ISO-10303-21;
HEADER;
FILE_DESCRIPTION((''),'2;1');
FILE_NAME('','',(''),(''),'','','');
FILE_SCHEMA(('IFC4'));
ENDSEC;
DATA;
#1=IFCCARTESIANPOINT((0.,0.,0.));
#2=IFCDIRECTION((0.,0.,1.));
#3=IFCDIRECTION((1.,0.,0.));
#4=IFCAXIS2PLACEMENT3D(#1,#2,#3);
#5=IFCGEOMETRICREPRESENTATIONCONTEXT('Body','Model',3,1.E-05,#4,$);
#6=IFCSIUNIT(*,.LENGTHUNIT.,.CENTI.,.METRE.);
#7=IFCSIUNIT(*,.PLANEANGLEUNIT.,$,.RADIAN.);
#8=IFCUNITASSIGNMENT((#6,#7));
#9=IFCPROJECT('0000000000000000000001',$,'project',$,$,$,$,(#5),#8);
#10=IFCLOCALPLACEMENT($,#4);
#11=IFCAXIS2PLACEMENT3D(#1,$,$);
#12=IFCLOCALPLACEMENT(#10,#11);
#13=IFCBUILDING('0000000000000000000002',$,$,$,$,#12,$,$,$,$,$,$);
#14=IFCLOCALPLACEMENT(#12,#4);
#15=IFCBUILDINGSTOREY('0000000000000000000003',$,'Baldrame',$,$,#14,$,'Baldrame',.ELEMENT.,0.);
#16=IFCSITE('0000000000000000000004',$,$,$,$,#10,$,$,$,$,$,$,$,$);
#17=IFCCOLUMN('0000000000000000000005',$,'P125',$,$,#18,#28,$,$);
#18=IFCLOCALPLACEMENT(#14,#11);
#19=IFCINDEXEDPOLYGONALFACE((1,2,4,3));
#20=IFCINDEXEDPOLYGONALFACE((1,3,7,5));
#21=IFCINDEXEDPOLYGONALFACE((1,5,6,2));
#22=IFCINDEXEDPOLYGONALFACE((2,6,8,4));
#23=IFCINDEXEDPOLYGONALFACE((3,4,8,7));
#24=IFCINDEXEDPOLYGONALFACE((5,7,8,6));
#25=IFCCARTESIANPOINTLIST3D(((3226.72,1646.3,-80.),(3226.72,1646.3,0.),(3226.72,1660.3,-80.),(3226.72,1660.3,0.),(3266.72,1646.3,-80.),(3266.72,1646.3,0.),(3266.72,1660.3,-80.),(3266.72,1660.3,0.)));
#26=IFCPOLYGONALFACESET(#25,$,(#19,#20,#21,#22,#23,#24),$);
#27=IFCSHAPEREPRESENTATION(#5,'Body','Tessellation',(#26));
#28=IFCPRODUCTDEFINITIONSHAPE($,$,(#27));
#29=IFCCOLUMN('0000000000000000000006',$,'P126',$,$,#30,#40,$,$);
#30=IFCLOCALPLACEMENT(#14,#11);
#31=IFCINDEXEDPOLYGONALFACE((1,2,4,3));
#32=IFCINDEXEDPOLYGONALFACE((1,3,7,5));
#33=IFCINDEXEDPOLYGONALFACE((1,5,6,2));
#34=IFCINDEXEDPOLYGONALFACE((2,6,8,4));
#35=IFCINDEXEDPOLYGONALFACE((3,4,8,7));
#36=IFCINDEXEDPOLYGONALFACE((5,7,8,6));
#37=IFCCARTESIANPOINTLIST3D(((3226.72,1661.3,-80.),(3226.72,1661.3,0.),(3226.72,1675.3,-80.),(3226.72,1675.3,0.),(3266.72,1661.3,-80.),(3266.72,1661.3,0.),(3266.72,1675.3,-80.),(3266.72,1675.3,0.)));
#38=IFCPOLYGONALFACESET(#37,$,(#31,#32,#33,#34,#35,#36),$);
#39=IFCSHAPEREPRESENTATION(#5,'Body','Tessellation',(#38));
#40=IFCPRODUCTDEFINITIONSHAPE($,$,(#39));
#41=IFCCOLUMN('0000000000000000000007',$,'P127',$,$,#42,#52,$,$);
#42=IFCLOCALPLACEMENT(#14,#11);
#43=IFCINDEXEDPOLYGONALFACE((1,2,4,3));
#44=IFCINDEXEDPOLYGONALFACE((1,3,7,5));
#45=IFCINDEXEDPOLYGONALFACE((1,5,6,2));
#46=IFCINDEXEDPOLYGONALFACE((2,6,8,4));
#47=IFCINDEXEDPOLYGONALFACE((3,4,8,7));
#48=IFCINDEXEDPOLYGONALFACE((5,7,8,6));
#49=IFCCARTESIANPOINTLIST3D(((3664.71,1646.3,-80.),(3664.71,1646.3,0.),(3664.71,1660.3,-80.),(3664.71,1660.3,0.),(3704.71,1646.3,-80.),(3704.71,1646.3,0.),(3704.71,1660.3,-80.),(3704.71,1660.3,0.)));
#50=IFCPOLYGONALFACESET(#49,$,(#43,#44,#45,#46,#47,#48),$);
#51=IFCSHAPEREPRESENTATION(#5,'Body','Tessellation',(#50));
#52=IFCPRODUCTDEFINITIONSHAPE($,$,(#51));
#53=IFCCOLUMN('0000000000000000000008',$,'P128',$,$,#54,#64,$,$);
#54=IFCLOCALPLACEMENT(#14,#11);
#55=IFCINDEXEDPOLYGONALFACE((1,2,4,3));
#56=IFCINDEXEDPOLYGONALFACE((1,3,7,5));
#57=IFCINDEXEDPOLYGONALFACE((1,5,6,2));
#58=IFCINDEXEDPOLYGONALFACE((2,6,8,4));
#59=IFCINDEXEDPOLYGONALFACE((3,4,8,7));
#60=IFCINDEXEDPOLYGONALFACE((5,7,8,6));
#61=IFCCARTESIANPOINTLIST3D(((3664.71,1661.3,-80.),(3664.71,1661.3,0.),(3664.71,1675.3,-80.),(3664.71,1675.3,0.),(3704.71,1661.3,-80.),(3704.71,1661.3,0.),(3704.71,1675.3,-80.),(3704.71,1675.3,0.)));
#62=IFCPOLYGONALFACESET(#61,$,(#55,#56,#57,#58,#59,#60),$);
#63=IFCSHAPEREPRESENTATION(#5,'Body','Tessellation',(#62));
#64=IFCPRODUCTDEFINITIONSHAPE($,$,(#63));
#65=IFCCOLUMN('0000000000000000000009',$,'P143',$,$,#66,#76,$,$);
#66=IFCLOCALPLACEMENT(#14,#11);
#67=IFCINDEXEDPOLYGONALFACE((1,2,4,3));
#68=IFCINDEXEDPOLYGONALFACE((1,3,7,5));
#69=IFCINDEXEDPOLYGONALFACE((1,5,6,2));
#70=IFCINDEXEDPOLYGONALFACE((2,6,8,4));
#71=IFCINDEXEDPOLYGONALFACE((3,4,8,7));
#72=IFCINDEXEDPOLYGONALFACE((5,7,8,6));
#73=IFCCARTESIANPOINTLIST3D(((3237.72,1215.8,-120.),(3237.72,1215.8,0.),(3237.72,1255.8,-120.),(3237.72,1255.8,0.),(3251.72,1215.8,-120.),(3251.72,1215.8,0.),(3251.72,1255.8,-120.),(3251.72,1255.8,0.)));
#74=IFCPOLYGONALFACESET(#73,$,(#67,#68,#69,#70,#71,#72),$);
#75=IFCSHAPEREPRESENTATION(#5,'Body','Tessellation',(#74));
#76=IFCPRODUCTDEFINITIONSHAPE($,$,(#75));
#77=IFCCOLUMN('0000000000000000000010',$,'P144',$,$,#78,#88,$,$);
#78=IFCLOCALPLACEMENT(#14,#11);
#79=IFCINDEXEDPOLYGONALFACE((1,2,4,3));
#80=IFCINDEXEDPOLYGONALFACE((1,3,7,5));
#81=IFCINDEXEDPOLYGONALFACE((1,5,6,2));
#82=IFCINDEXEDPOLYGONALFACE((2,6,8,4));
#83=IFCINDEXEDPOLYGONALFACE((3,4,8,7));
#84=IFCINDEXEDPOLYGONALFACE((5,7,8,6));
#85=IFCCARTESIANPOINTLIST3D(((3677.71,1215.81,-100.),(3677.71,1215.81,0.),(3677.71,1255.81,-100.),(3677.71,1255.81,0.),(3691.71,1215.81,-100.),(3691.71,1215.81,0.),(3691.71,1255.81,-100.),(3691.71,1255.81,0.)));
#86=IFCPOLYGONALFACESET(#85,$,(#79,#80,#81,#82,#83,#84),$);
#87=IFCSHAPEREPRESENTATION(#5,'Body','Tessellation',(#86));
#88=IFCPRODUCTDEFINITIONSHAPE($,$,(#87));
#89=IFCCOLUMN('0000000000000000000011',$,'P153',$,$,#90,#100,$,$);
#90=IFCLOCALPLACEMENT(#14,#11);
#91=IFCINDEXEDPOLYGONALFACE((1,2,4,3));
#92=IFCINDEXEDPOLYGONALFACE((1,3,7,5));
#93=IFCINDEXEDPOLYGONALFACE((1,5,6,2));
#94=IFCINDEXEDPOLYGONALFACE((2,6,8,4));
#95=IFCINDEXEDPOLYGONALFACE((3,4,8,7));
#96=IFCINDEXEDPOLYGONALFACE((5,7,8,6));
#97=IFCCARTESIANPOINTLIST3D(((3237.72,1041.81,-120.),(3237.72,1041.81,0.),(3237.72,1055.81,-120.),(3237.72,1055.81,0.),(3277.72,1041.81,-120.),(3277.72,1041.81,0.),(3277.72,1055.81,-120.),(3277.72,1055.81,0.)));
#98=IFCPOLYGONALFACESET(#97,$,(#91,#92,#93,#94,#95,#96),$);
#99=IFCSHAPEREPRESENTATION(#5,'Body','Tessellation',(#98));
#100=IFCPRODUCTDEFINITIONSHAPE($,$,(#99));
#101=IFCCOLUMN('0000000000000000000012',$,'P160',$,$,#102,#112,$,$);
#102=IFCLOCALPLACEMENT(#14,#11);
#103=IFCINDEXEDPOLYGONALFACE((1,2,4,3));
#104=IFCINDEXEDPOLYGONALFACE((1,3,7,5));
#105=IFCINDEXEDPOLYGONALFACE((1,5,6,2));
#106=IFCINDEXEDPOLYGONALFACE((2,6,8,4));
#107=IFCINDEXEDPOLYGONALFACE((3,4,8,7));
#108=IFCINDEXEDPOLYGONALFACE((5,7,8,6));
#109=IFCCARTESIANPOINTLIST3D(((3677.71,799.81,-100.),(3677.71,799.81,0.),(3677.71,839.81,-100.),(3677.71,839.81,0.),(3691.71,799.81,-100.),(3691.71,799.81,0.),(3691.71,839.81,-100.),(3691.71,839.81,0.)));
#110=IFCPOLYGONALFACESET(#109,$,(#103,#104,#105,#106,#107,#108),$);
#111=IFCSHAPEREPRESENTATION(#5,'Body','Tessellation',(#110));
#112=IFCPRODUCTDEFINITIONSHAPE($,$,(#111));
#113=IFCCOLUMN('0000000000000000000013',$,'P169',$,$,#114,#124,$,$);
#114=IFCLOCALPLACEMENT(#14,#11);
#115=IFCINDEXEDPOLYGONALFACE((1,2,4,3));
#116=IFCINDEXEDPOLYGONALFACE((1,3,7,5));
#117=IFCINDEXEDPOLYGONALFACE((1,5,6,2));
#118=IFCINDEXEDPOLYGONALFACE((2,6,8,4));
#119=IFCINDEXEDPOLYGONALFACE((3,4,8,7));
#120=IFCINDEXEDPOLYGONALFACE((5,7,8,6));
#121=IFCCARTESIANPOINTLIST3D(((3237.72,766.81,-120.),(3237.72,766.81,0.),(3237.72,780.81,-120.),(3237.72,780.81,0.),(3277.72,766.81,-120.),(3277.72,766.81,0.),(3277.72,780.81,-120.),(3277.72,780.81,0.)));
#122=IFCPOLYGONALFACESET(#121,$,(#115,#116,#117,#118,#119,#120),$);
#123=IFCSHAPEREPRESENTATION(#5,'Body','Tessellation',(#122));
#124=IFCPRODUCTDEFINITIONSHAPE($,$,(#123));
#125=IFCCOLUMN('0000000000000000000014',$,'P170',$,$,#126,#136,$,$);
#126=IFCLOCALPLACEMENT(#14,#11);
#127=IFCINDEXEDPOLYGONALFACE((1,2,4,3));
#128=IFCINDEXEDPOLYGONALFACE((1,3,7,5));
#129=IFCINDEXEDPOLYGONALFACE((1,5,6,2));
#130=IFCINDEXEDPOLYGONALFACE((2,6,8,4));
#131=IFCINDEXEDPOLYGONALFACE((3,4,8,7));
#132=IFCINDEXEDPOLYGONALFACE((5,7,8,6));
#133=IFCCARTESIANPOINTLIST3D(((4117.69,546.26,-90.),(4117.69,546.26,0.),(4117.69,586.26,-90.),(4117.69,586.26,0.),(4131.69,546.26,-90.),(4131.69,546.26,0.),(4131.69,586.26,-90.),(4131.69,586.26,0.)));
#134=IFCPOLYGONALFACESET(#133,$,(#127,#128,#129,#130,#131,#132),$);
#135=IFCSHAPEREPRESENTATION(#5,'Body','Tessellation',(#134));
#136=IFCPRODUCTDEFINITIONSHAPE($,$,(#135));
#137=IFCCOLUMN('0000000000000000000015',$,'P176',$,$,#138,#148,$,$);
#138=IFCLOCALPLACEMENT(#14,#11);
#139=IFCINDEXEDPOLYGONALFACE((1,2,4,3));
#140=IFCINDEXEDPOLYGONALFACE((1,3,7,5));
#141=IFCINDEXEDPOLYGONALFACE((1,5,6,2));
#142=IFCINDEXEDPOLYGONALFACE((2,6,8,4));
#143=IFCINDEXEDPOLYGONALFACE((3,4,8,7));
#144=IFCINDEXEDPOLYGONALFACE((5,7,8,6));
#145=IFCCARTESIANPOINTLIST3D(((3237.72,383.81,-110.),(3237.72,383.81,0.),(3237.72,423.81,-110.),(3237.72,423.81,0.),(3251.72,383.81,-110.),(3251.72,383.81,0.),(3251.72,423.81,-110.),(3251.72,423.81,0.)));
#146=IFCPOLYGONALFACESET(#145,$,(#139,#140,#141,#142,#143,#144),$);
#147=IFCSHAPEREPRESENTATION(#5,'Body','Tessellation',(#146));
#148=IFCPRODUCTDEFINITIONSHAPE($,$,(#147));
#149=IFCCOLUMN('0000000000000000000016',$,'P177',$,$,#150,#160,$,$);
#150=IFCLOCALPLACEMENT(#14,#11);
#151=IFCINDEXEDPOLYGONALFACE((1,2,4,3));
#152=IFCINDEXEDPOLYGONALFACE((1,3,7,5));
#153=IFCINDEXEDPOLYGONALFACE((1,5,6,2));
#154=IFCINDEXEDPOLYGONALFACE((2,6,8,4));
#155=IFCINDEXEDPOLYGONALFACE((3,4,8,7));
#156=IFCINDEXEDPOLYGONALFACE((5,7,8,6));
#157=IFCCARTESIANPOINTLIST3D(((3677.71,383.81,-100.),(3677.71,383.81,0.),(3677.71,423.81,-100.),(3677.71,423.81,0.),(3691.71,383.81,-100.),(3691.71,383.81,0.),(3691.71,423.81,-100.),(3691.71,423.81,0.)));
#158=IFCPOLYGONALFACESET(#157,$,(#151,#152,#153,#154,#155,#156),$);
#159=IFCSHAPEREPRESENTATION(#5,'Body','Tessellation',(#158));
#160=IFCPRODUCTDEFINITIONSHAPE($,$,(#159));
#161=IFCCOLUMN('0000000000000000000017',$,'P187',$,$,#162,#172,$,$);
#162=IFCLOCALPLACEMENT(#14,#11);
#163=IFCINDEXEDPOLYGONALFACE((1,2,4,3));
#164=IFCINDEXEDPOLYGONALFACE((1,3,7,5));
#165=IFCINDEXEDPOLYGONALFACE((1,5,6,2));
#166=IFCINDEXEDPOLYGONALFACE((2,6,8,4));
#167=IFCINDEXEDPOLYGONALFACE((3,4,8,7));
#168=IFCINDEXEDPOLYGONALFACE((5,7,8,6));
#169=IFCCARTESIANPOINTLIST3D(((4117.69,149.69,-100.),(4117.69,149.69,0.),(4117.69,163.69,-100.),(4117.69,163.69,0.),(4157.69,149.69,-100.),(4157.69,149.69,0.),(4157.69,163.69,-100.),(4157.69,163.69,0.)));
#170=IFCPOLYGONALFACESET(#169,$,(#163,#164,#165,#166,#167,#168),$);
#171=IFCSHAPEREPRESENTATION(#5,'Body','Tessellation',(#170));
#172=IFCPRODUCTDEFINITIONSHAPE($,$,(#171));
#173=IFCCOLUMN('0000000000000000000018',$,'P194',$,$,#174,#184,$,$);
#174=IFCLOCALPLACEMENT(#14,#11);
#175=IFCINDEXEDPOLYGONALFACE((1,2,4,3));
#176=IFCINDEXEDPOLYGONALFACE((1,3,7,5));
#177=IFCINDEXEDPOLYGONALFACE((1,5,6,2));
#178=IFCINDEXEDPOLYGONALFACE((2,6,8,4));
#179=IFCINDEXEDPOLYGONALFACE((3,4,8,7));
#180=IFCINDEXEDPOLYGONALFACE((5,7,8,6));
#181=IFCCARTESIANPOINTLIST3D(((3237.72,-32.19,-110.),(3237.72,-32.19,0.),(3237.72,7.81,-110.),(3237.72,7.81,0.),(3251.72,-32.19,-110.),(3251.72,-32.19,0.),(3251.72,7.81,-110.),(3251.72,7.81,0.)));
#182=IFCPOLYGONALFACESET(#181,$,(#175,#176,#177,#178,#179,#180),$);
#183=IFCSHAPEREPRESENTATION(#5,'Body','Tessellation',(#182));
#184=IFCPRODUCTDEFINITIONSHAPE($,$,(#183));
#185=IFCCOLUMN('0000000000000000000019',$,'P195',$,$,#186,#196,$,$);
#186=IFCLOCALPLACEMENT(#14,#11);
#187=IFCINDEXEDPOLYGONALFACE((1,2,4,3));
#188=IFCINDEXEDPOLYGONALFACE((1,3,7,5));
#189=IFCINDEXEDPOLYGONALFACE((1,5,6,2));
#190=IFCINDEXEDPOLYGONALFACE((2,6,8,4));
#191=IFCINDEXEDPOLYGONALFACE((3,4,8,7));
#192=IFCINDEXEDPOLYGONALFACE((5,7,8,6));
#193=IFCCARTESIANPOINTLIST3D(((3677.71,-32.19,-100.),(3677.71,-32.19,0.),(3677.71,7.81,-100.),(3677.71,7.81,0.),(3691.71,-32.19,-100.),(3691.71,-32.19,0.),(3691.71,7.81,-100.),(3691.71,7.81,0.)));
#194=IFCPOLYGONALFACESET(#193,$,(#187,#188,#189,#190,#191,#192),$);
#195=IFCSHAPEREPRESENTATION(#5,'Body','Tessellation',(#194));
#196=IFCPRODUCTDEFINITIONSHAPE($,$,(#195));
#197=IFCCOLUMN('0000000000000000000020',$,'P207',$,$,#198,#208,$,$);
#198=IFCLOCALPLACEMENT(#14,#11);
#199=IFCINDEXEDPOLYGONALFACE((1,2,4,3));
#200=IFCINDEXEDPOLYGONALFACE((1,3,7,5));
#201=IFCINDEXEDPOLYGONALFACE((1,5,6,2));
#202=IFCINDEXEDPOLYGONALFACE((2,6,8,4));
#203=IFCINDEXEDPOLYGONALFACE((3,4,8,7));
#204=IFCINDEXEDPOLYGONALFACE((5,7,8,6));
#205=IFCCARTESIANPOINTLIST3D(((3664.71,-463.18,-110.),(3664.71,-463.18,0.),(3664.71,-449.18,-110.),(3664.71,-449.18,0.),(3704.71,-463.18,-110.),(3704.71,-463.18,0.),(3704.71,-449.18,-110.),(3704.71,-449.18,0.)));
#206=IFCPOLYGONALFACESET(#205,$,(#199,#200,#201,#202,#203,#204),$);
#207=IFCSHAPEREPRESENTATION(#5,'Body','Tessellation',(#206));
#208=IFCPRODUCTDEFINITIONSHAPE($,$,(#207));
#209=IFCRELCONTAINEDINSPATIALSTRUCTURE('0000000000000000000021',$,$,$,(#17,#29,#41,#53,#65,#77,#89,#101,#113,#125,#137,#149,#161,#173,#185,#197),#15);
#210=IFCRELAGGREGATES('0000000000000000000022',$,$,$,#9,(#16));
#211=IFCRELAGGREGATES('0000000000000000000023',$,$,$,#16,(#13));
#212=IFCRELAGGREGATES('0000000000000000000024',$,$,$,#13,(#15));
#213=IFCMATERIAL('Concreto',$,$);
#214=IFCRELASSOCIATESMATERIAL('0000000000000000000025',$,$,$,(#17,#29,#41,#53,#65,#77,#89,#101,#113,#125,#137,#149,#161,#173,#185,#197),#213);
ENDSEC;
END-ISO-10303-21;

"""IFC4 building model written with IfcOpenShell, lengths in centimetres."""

from ifc_helpers import new_model, si_unit, frame, origin, origin_with_axes, origin_2d_with_axis, place, context, project, spatial, rectangle, extrude, material, element, save


model = new_model("IFC4")

# Units and contexts
model_context = context("Model", 3, precision=1e-05, world=origin_with_axes(), identifier="Body")
ifc_project = project(units=[si_unit("LENGTHUNIT", "METRE", prefix="CENTI"), si_unit("PLANEANGLEUNIT", "RADIAN")], contexts=[model_context])

# Site, building, storey
site_placement = place(None, origin_with_axes())
site = spatial("IfcSite", under=ifc_project, at=site_placement)
building_placement = place(site_placement, origin())
building = spatial("IfcBuilding", under=site, at=building_placement)
storey_placement = place(building_placement, origin_with_axes())
storey = spatial("IfcBuildingStorey", under=building, at=storey_placement, Name="Baldrame", LongName="Baldrame", CompositionType="ELEMENT", Elevation=0.0)

# Columns
ifc_material = material(Name="Concreto")
for number, where, z_axis, x_axis, name in (
    (1, (3246.72, 1653.3, 0.0), (0.0, 0.0, 1.0), (1.0, 0.0, 0.0), "P125"),
    (2, (3246.72, 1668.3, 0.0), (0.0, 0.0, 1.0), (1.0, 0.0, 0.0), "P126"),
    (3, (3684.71, 1653.3, 0.0), (0.0, 0.0, 1.0), (1.0, 0.0, 0.0), "P127"),
    (4, (3684.71, 1668.3, 0.0), (0.0, 0.0, 1.0), (1.0, 0.0, 0.0), "P128"),
):
    element("IfcColumn", number, at=place(storey_placement, frame(where, z_axis=z_axis, x_axis=x_axis)), inside=storey, material=ifc_material, Name=name, context=model_context, shape_type="SolidModel", body=[
        extrude(rectangle(XDim=14.0, YDim=40.0, at=origin_2d_with_axis()), frame((0.0, 0.0, -80.0), z_axis=(0.0, 0.0, 1.0), x_axis=(0.0, -1.0, 0.0)), (0.0, 0.0, 1.0), 80.0),
    ])
column_1_placement = place(storey_placement, frame((3244.72, 1235.8, 0.0), z_axis=(0.0, 0.0, 1.0), x_axis=(1.0, 0.0, 0.0)))
element("IfcColumn", 5, at=column_1_placement, inside=storey, material=ifc_material, Name="P143", context=model_context, shape_type="SolidModel", body=[
    extrude(rectangle(XDim=14.0, YDim=40.0, at=origin_2d_with_axis()), frame((0.0, 0.0, -120.0), z_axis=(0.0, 0.0, 1.0), x_axis=(1.0, 0.0, 0.0)), (0.0, 0.0, 1.0), 120.0),
])
column_2_placement = place(storey_placement, frame((3684.71, 1235.81, 0.0), z_axis=(0.0, 0.0, 1.0), x_axis=(1.0, 0.0, 0.0)))
element("IfcColumn", 6, at=column_2_placement, inside=storey, material=ifc_material, Name="P144", context=model_context, shape_type="SolidModel", body=[
    extrude(rectangle(XDim=14.0, YDim=40.0, at=origin_2d_with_axis()), frame((0.0, 0.0, -100.0), z_axis=(0.0, 0.0, 1.0), x_axis=(1.0, 0.0, 0.0)), (0.0, 0.0, 1.0), 100.0),
])
column_3_placement = place(storey_placement, frame((3257.72, 1048.81, 0.0), z_axis=(0.0, 0.0, 1.0), x_axis=(1.0, 0.0, 0.0)))
element("IfcColumn", 7, at=column_3_placement, inside=storey, material=ifc_material, Name="P153", context=model_context, shape_type="SolidModel", body=[
    extrude(rectangle(XDim=14.0, YDim=40.0, at=origin_2d_with_axis()), frame((0.0, 0.0, -120.0), z_axis=(0.0, 0.0, 1.0), x_axis=(0.0, -1.0, 0.0)), (0.0, 0.0, 1.0), 120.0),
])
column_4_placement = place(storey_placement, frame((3684.71, 819.81, 0.0), z_axis=(0.0, 0.0, 1.0), x_axis=(1.0, 0.0, 0.0)))
element("IfcColumn", 8, at=column_4_placement, inside=storey, material=ifc_material, Name="P160", context=model_context, shape_type="SolidModel", body=[
    extrude(rectangle(XDim=14.0, YDim=40.0, at=origin_2d_with_axis()), frame((0.0, 0.0, -100.0), z_axis=(0.0, 0.0, 1.0), x_axis=(1.0, 0.0, 0.0)), (0.0, 0.0, 1.0), 100.0),
])
column_5_placement = place(storey_placement, frame((3257.72, 773.81, 0.0), z_axis=(0.0, 0.0, 1.0), x_axis=(1.0, 0.0, 0.0)))
element("IfcColumn", 9, at=column_5_placement, inside=storey, material=ifc_material, Name="P169", context=model_context, shape_type="SolidModel", body=[
    extrude(rectangle(XDim=14.0, YDim=40.0, at=origin_2d_with_axis()), frame((0.0, 0.0, -120.0), z_axis=(0.0, 0.0, 1.0), x_axis=(0.0, -1.0, 0.0)), (0.0, 0.0, 1.0), 120.0),
])
column_6_placement = place(storey_placement, frame((4124.69, 566.26, 0.0), z_axis=(0.0, 0.0, 1.0), x_axis=(1.0, 0.0, 0.0)))
element("IfcColumn", 10, at=column_6_placement, inside=storey, material=ifc_material, Name="P170", context=model_context, shape_type="SolidModel", body=[
    extrude(rectangle(XDim=14.0, YDim=40.0, at=origin_2d_with_axis()), frame((0.0, 0.0, -90.0), z_axis=(0.0, 0.0, 1.0), x_axis=(-1.0, 0.0, 0.0)), (0.0, 0.0, 1.0), 90.0),
])
column_7_placement = place(storey_placement, frame((3244.72, 403.81, 0.0), z_axis=(0.0, 0.0, 1.0), x_axis=(1.0, 0.0, 0.0)))
element("IfcColumn", 11, at=column_7_placement, inside=storey, material=ifc_material, Name="P176", context=model_context, shape_type="SolidModel", body=[
    extrude(rectangle(XDim=14.0, YDim=40.0, at=origin_2d_with_axis()), frame((0.0, 0.0, -110.0), z_axis=(0.0, 0.0, 1.0), x_axis=(1.0, 0.0, 0.0)), (0.0, 0.0, 1.0), 110.0),
])
column_8_placement = place(storey_placement, frame((3684.71, 403.81, 0.0), z_axis=(0.0, 0.0, 1.0), x_axis=(1.0, 0.0, 0.0)))
element("IfcColumn", 12, at=column_8_placement, inside=storey, material=ifc_material, Name="P177", context=model_context, shape_type="SolidModel", body=[
    extrude(rectangle(XDim=14.0, YDim=40.0, at=origin_2d_with_axis()), frame((0.0, 0.0, -100.0), z_axis=(0.0, 0.0, 1.0), x_axis=(1.0, 0.0, 0.0)), (0.0, 0.0, 1.0), 100.0),
])
column_9_placement = place(storey_placement, frame((4137.69, 156.69, 0.0), z_axis=(0.0, 0.0, 1.0), x_axis=(1.0, 0.0, 0.0)))
element("IfcColumn", 13, at=column_9_placement, inside=storey, material=ifc_material, Name="P187", context=model_context, shape_type="SolidModel", body=[
    extrude(rectangle(XDim=14.0, YDim=40.0, at=origin_2d_with_axis()), frame((0.0, 0.0, -100.0), z_axis=(0.0, 0.0, 1.0), x_axis=(0.0, -1.0, 0.0)), (0.0, 0.0, 1.0), 100.0),
])
column_10_placement = place(storey_placement, frame((3244.72, -12.19, 0.0), z_axis=(0.0, 0.0, 1.0), x_axis=(1.0, 0.0, 0.0)))
element("IfcColumn", 14, at=column_10_placement, inside=storey, material=ifc_material, Name="P194", context=model_context, shape_type="SolidModel", body=[
    extrude(rectangle(XDim=14.0, YDim=40.0, at=origin_2d_with_axis()), frame((0.0, 0.0, -110.0), z_axis=(0.0, 0.0, 1.0), x_axis=(1.0, 0.0, 0.0)), (0.0, 0.0, 1.0), 110.0),
])
column_11_placement = place(storey_placement, frame((3684.71, -12.19, 0.0), z_axis=(0.0, 0.0, 1.0), x_axis=(1.0, 0.0, 0.0)))
element("IfcColumn", 15, at=column_11_placement, inside=storey, material=ifc_material, Name="P195", context=model_context, shape_type="SolidModel", body=[
    extrude(rectangle(XDim=14.0, YDim=40.0, at=origin_2d_with_axis()), frame((0.0, 0.0, -100.0), z_axis=(0.0, 0.0, 1.0), x_axis=(1.0, 0.0, 0.0)), (0.0, 0.0, 1.0), 100.0),
])
column_12_placement = place(storey_placement, frame((3684.71, -456.18, 0.0), z_axis=(0.0, 0.0, 1.0), x_axis=(1.0, 0.0, 0.0)))
element("IfcColumn", 16, at=column_12_placement, inside=storey, material=ifc_material, Name="P207", context=model_context, shape_type="SolidModel", body=[
    extrude(rectangle(XDim=14.0, YDim=40.0, at=origin_2d_with_axis()), frame((0.0, 0.0, -110.0), z_axis=(0.0, 0.0, 1.0), x_axis=(0.0, -1.0, 0.0)), (0.0, 0.0, 1.0), 110.0),
])

save(model, "model.ifc")
